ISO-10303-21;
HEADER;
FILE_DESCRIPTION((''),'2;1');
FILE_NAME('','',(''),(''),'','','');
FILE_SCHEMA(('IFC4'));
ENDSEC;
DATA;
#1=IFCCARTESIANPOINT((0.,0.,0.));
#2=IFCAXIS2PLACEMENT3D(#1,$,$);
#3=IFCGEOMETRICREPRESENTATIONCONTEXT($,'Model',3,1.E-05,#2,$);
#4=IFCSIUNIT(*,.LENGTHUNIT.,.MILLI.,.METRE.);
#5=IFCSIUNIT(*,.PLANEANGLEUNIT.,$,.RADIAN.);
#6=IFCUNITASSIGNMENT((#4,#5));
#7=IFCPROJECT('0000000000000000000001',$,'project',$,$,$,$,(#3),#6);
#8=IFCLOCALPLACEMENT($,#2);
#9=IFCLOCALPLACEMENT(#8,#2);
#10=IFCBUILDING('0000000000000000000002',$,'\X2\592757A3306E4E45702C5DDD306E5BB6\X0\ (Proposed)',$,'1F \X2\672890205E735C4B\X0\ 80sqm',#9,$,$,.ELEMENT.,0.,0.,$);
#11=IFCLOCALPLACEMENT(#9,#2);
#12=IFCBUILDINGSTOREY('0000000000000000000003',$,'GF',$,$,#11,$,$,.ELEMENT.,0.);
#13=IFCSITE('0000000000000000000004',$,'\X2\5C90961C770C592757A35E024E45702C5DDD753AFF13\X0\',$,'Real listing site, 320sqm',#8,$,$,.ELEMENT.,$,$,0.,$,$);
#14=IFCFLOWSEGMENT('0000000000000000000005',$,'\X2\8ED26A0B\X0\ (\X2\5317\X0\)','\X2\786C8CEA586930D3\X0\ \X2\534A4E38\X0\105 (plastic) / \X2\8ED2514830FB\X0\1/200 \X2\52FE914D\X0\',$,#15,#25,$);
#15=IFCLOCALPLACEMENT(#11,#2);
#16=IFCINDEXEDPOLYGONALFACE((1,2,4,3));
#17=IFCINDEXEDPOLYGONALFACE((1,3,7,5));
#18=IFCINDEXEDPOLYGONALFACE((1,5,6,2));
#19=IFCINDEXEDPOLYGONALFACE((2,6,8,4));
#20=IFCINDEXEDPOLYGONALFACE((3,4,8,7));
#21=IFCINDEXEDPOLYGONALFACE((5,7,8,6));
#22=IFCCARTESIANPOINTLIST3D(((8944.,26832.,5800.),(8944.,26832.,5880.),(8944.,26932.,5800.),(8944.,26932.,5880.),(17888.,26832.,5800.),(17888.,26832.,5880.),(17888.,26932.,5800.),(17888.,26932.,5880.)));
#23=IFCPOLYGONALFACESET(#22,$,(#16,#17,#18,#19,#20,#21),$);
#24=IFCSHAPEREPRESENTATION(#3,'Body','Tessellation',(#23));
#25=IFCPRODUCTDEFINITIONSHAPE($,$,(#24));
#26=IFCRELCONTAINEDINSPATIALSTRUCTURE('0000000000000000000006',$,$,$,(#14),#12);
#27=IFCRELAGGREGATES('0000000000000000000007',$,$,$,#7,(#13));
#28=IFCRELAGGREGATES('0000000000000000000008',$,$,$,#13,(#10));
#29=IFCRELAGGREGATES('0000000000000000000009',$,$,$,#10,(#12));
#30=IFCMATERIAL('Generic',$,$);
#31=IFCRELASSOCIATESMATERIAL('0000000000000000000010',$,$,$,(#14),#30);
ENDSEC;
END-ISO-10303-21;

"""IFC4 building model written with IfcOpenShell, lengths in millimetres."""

from ifc_helpers import new_model, si_unit, frame, frame_2d, origin, place, context, project, spatial, rectangle, extrude, material, element, save


model = new_model("IFC4")

# Units and contexts
model_context = context("Model", 3, precision=1e-05, world=origin())
ifc_project = project(units=[si_unit("LENGTHUNIT", "METRE", prefix="MILLI"), si_unit("PLANEANGLEUNIT", "RADIAN")], contexts=[model_context])

# Site, building, storey
site_placement = place(None, origin())
site = spatial("IfcSite", under=ifc_project, at=site_placement, Name="岐阜県大垣市久瀬川町３", ObjectType="Real listing site, 320sqm", CompositionType="ELEMENT", RefElevation=0.0)
building_placement = place(site_placement, origin())
building = spatial("IfcBuilding", under=site, at=building_placement, Name="大垣の久瀬川の家 (Proposed)", ObjectType="1F 木造平屋 80sqm", CompositionType="ELEMENT", ElevationOfRefHeight=0.0, ElevationOfTerrain=0.0)
storey_placement = place(building_placement, origin())
storey = spatial("IfcBuildingStorey", under=building, at=storey_placement, Name="GF", CompositionType="ELEMENT", Elevation=0.0)

# Shared definitions
ifc_material_1 = material(Name="Generic")

# Flow segment
flow_segment_1_placement = place(storey_placement, frame((4472.0, 13416.0, 2900.0)))
element("IfcFlowSegment", 1, at=flow_segment_1_placement, inside=storey, material=ifc_material_1, Name="軒樋 (北)", Description="硬質塩ビ 半丸105 (plastic) / 軒先・1/200 勾配", context=model_context, shape_type="SweptSolid", body=[
    extrude(rectangle(XDim=8944.0, YDim=100.0, at=frame_2d((4472.0, 50.0))), frame((4472.0, 13416.0, 2900.0)), (0.0, 0.0, 1.0), 80.0),
])

save(model, "model.ifc")
